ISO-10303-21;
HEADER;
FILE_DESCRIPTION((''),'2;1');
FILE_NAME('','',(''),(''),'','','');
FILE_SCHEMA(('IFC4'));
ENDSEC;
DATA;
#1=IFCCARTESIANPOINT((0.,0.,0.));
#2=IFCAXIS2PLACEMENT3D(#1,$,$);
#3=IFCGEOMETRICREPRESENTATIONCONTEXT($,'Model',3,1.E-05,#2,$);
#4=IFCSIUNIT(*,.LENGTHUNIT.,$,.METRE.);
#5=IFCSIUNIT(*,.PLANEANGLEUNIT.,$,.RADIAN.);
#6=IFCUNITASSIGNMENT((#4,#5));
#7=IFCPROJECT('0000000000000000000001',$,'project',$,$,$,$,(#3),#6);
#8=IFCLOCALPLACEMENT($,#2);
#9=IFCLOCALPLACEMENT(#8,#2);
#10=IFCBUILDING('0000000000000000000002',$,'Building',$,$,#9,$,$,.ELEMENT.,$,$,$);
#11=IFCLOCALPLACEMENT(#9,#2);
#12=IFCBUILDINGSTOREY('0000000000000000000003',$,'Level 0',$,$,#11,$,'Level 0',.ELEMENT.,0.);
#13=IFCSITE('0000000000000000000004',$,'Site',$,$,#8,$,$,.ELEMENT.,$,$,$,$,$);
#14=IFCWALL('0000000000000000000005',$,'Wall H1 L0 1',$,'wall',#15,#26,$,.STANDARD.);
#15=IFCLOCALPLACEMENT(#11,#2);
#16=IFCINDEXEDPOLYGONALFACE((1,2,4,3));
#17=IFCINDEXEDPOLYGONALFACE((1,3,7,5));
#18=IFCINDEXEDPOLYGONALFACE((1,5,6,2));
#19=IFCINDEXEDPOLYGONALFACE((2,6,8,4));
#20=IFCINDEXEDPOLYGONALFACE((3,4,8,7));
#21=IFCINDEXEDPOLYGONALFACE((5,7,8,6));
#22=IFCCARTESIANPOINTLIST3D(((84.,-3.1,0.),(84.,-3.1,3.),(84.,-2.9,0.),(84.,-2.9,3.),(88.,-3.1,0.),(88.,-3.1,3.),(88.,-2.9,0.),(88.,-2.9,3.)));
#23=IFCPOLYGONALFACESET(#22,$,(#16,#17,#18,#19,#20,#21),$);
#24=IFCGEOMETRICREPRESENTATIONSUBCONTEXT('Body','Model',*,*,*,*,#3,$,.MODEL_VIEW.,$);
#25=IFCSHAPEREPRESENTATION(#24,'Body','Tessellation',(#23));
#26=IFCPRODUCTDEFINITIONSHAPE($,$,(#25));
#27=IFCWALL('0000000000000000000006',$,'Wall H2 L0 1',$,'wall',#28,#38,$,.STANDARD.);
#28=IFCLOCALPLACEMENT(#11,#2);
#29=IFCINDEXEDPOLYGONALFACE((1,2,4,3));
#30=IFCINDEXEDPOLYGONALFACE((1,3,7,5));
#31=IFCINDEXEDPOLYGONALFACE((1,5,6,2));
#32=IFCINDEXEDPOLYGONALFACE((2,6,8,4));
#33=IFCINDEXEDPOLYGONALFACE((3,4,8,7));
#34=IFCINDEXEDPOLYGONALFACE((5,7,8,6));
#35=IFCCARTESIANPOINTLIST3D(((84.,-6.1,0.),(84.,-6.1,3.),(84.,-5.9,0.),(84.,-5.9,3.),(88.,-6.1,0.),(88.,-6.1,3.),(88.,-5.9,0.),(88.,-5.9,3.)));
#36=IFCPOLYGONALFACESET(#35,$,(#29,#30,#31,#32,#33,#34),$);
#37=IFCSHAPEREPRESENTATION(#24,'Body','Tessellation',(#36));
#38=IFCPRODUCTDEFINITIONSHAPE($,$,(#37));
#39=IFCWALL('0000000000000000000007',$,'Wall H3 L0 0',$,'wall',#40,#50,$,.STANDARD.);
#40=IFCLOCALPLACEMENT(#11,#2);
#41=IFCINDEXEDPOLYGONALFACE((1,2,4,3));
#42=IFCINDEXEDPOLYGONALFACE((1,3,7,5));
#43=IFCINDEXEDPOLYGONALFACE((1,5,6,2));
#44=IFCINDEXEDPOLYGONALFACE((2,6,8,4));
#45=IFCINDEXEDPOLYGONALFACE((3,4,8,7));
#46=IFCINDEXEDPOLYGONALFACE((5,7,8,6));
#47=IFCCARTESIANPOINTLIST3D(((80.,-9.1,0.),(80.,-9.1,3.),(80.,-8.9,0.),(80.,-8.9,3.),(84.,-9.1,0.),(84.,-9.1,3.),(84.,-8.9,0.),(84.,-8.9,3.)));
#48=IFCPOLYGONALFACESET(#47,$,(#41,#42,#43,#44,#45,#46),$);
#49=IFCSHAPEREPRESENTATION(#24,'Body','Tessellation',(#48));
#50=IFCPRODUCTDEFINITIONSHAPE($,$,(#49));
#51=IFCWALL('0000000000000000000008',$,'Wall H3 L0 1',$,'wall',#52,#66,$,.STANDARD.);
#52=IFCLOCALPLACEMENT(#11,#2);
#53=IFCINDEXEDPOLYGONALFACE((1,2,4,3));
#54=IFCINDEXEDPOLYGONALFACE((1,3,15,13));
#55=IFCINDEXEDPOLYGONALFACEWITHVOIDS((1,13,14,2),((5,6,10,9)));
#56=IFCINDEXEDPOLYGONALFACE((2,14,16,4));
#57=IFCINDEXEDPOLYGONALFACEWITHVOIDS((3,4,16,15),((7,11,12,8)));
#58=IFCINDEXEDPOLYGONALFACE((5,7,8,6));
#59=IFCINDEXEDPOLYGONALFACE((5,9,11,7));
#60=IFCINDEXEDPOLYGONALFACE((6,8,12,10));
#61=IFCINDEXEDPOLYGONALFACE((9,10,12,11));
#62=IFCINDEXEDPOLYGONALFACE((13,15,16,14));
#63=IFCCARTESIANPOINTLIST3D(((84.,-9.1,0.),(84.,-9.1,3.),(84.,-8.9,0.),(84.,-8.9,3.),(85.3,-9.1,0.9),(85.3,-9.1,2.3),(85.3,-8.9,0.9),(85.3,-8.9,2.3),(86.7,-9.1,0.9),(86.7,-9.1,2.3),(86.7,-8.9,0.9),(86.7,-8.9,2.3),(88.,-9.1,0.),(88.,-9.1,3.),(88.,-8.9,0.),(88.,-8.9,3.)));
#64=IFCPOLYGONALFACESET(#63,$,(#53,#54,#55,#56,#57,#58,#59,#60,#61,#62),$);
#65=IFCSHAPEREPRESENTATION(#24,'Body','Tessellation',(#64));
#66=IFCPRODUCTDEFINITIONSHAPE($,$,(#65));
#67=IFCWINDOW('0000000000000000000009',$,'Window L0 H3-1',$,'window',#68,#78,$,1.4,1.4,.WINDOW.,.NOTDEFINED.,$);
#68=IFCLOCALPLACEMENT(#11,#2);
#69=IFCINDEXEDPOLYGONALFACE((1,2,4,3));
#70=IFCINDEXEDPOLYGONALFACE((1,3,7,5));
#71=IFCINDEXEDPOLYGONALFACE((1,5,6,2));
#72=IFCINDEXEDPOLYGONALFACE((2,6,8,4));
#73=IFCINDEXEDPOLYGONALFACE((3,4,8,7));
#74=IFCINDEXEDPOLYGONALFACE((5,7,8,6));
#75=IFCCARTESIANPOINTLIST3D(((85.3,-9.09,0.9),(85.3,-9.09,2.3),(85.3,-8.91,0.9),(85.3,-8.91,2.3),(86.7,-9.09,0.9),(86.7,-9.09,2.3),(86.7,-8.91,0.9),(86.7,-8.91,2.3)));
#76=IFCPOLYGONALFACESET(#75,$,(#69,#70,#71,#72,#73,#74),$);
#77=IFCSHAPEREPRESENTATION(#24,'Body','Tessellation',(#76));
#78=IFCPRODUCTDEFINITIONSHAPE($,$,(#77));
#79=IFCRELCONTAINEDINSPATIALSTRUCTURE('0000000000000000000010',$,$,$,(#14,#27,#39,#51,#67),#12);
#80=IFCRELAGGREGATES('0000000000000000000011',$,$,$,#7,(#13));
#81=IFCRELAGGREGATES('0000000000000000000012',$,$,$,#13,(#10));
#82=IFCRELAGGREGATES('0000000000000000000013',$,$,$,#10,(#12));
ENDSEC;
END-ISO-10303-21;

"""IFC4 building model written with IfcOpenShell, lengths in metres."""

from ifc_helpers import new_model, si_unit, frame, frame_2d, origin, origin_2d, place, context, subcontext, project, spatial, rectangle, extrude, element, fill, save


model = new_model("IFC4")

# Units and contexts
model_context = context("Model", 3, precision=1e-05, world=origin())
body_context = subcontext(model_context, "Body", "Model", "MODEL_VIEW")
ifc_project = project(units=[si_unit("LENGTHUNIT", "METRE"), si_unit("PLANEANGLEUNIT", "RADIAN")], contexts=[model_context])

# Site, building, storey
site_placement = place(None, origin())
site = spatial("IfcSite", under=ifc_project, at=site_placement, Name="Site", CompositionType="ELEMENT")
building_placement = place(site_placement, origin())
building = spatial("IfcBuilding", under=site, at=building_placement, Name="Building", CompositionType="ELEMENT")
storey_placement = place(building_placement, origin())
storey = spatial("IfcBuildingStorey", under=building, at=storey_placement, Name="Level 0", LongName="Level 0", CompositionType="ELEMENT", Elevation=0.0)

# Walls
for number, where, z_axis, x_axis, name in (
    (1, (84.0, -3.0, 0.0), (0.0, 0.0, 1.0), (1.0, 0.0, 0.0), "Wall H1 L0 1"),
    (2, (84.0, -6.0, 0.0), (0.0, 0.0, 1.0), (1.0, 0.0, 0.0), "Wall H2 L0 1"),
    (3, (80.0, -9.0, 0.0), (0.0, 0.0, 1.0), (1.0, 0.0, 0.0), "Wall H3 L0 0"),
):
    element("IfcWall", number, at=place(storey_placement, frame(where, z_axis=z_axis, x_axis=x_axis)), inside=storey, Name=name, ObjectType="wall", PredefinedType="STANDARD", context=body_context, shape_type="SweptSolid", body=[
        extrude(rectangle(XDim=4.0, YDim=0.2, at=frame_2d((2.0, 0.0))), origin(), (0.0, 0.0, 1.0), 3.0),
    ])

# Wall, opening, window
wall_1_placement = place(storey_placement, frame((84.0, -9.0, 0.0), z_axis=(0.0, 0.0, 1.0), x_axis=(1.0, 0.0, 0.0)))
wall_1 = element("IfcWall", 4, at=wall_1_placement, inside=storey, Name="Wall H3 L0 1", ObjectType="wall", PredefinedType="STANDARD", context=body_context, shape_type="SweptSolid", body=[
    extrude(rectangle(XDim=4.0, YDim=0.2, at=frame_2d((2.0, 0.0))), origin(), (0.0, 0.0, 1.0), 3.0),
])
opening_1_placement = place(storey_placement, frame((86.0, -9.0, 0.9), z_axis=(0.0, 0.0, 1.0), x_axis=(1.0, 0.0, 0.0)))
opening_1 = element("IfcOpeningElement", 5, at=opening_1_placement, cuts=wall_1, ObjectType="Opening", PredefinedType="OPENING", context=body_context, shape_type="SweptSolid", body=[
    extrude(rectangle(XDim=1.4, YDim=0.22, at=origin_2d()), origin(), (0.0, 0.0, 1.0), 1.4),
])
window_1_placement = place(storey_placement, frame((86.0, -9.0, 0.9), z_axis=(0.0, 0.0, 1.0), x_axis=(1.0, 0.0, 0.0)))
window_1 = element("IfcWindow", 6, at=window_1_placement, inside=storey, Name="Window L0 H3-1", ObjectType="window", OverallHeight=1.4, OverallWidth=1.4, PartitioningType="NOTDEFINED", PredefinedType="WINDOW", context=body_context, shape_type="SweptSolid", body=[
    extrude(rectangle(XDim=1.4, YDim=0.18, at=origin_2d()), origin(), (0.0, 0.0, 1.0), 1.4),
])
fill(opening_1, window_1)

save(model, "model.ifc")
